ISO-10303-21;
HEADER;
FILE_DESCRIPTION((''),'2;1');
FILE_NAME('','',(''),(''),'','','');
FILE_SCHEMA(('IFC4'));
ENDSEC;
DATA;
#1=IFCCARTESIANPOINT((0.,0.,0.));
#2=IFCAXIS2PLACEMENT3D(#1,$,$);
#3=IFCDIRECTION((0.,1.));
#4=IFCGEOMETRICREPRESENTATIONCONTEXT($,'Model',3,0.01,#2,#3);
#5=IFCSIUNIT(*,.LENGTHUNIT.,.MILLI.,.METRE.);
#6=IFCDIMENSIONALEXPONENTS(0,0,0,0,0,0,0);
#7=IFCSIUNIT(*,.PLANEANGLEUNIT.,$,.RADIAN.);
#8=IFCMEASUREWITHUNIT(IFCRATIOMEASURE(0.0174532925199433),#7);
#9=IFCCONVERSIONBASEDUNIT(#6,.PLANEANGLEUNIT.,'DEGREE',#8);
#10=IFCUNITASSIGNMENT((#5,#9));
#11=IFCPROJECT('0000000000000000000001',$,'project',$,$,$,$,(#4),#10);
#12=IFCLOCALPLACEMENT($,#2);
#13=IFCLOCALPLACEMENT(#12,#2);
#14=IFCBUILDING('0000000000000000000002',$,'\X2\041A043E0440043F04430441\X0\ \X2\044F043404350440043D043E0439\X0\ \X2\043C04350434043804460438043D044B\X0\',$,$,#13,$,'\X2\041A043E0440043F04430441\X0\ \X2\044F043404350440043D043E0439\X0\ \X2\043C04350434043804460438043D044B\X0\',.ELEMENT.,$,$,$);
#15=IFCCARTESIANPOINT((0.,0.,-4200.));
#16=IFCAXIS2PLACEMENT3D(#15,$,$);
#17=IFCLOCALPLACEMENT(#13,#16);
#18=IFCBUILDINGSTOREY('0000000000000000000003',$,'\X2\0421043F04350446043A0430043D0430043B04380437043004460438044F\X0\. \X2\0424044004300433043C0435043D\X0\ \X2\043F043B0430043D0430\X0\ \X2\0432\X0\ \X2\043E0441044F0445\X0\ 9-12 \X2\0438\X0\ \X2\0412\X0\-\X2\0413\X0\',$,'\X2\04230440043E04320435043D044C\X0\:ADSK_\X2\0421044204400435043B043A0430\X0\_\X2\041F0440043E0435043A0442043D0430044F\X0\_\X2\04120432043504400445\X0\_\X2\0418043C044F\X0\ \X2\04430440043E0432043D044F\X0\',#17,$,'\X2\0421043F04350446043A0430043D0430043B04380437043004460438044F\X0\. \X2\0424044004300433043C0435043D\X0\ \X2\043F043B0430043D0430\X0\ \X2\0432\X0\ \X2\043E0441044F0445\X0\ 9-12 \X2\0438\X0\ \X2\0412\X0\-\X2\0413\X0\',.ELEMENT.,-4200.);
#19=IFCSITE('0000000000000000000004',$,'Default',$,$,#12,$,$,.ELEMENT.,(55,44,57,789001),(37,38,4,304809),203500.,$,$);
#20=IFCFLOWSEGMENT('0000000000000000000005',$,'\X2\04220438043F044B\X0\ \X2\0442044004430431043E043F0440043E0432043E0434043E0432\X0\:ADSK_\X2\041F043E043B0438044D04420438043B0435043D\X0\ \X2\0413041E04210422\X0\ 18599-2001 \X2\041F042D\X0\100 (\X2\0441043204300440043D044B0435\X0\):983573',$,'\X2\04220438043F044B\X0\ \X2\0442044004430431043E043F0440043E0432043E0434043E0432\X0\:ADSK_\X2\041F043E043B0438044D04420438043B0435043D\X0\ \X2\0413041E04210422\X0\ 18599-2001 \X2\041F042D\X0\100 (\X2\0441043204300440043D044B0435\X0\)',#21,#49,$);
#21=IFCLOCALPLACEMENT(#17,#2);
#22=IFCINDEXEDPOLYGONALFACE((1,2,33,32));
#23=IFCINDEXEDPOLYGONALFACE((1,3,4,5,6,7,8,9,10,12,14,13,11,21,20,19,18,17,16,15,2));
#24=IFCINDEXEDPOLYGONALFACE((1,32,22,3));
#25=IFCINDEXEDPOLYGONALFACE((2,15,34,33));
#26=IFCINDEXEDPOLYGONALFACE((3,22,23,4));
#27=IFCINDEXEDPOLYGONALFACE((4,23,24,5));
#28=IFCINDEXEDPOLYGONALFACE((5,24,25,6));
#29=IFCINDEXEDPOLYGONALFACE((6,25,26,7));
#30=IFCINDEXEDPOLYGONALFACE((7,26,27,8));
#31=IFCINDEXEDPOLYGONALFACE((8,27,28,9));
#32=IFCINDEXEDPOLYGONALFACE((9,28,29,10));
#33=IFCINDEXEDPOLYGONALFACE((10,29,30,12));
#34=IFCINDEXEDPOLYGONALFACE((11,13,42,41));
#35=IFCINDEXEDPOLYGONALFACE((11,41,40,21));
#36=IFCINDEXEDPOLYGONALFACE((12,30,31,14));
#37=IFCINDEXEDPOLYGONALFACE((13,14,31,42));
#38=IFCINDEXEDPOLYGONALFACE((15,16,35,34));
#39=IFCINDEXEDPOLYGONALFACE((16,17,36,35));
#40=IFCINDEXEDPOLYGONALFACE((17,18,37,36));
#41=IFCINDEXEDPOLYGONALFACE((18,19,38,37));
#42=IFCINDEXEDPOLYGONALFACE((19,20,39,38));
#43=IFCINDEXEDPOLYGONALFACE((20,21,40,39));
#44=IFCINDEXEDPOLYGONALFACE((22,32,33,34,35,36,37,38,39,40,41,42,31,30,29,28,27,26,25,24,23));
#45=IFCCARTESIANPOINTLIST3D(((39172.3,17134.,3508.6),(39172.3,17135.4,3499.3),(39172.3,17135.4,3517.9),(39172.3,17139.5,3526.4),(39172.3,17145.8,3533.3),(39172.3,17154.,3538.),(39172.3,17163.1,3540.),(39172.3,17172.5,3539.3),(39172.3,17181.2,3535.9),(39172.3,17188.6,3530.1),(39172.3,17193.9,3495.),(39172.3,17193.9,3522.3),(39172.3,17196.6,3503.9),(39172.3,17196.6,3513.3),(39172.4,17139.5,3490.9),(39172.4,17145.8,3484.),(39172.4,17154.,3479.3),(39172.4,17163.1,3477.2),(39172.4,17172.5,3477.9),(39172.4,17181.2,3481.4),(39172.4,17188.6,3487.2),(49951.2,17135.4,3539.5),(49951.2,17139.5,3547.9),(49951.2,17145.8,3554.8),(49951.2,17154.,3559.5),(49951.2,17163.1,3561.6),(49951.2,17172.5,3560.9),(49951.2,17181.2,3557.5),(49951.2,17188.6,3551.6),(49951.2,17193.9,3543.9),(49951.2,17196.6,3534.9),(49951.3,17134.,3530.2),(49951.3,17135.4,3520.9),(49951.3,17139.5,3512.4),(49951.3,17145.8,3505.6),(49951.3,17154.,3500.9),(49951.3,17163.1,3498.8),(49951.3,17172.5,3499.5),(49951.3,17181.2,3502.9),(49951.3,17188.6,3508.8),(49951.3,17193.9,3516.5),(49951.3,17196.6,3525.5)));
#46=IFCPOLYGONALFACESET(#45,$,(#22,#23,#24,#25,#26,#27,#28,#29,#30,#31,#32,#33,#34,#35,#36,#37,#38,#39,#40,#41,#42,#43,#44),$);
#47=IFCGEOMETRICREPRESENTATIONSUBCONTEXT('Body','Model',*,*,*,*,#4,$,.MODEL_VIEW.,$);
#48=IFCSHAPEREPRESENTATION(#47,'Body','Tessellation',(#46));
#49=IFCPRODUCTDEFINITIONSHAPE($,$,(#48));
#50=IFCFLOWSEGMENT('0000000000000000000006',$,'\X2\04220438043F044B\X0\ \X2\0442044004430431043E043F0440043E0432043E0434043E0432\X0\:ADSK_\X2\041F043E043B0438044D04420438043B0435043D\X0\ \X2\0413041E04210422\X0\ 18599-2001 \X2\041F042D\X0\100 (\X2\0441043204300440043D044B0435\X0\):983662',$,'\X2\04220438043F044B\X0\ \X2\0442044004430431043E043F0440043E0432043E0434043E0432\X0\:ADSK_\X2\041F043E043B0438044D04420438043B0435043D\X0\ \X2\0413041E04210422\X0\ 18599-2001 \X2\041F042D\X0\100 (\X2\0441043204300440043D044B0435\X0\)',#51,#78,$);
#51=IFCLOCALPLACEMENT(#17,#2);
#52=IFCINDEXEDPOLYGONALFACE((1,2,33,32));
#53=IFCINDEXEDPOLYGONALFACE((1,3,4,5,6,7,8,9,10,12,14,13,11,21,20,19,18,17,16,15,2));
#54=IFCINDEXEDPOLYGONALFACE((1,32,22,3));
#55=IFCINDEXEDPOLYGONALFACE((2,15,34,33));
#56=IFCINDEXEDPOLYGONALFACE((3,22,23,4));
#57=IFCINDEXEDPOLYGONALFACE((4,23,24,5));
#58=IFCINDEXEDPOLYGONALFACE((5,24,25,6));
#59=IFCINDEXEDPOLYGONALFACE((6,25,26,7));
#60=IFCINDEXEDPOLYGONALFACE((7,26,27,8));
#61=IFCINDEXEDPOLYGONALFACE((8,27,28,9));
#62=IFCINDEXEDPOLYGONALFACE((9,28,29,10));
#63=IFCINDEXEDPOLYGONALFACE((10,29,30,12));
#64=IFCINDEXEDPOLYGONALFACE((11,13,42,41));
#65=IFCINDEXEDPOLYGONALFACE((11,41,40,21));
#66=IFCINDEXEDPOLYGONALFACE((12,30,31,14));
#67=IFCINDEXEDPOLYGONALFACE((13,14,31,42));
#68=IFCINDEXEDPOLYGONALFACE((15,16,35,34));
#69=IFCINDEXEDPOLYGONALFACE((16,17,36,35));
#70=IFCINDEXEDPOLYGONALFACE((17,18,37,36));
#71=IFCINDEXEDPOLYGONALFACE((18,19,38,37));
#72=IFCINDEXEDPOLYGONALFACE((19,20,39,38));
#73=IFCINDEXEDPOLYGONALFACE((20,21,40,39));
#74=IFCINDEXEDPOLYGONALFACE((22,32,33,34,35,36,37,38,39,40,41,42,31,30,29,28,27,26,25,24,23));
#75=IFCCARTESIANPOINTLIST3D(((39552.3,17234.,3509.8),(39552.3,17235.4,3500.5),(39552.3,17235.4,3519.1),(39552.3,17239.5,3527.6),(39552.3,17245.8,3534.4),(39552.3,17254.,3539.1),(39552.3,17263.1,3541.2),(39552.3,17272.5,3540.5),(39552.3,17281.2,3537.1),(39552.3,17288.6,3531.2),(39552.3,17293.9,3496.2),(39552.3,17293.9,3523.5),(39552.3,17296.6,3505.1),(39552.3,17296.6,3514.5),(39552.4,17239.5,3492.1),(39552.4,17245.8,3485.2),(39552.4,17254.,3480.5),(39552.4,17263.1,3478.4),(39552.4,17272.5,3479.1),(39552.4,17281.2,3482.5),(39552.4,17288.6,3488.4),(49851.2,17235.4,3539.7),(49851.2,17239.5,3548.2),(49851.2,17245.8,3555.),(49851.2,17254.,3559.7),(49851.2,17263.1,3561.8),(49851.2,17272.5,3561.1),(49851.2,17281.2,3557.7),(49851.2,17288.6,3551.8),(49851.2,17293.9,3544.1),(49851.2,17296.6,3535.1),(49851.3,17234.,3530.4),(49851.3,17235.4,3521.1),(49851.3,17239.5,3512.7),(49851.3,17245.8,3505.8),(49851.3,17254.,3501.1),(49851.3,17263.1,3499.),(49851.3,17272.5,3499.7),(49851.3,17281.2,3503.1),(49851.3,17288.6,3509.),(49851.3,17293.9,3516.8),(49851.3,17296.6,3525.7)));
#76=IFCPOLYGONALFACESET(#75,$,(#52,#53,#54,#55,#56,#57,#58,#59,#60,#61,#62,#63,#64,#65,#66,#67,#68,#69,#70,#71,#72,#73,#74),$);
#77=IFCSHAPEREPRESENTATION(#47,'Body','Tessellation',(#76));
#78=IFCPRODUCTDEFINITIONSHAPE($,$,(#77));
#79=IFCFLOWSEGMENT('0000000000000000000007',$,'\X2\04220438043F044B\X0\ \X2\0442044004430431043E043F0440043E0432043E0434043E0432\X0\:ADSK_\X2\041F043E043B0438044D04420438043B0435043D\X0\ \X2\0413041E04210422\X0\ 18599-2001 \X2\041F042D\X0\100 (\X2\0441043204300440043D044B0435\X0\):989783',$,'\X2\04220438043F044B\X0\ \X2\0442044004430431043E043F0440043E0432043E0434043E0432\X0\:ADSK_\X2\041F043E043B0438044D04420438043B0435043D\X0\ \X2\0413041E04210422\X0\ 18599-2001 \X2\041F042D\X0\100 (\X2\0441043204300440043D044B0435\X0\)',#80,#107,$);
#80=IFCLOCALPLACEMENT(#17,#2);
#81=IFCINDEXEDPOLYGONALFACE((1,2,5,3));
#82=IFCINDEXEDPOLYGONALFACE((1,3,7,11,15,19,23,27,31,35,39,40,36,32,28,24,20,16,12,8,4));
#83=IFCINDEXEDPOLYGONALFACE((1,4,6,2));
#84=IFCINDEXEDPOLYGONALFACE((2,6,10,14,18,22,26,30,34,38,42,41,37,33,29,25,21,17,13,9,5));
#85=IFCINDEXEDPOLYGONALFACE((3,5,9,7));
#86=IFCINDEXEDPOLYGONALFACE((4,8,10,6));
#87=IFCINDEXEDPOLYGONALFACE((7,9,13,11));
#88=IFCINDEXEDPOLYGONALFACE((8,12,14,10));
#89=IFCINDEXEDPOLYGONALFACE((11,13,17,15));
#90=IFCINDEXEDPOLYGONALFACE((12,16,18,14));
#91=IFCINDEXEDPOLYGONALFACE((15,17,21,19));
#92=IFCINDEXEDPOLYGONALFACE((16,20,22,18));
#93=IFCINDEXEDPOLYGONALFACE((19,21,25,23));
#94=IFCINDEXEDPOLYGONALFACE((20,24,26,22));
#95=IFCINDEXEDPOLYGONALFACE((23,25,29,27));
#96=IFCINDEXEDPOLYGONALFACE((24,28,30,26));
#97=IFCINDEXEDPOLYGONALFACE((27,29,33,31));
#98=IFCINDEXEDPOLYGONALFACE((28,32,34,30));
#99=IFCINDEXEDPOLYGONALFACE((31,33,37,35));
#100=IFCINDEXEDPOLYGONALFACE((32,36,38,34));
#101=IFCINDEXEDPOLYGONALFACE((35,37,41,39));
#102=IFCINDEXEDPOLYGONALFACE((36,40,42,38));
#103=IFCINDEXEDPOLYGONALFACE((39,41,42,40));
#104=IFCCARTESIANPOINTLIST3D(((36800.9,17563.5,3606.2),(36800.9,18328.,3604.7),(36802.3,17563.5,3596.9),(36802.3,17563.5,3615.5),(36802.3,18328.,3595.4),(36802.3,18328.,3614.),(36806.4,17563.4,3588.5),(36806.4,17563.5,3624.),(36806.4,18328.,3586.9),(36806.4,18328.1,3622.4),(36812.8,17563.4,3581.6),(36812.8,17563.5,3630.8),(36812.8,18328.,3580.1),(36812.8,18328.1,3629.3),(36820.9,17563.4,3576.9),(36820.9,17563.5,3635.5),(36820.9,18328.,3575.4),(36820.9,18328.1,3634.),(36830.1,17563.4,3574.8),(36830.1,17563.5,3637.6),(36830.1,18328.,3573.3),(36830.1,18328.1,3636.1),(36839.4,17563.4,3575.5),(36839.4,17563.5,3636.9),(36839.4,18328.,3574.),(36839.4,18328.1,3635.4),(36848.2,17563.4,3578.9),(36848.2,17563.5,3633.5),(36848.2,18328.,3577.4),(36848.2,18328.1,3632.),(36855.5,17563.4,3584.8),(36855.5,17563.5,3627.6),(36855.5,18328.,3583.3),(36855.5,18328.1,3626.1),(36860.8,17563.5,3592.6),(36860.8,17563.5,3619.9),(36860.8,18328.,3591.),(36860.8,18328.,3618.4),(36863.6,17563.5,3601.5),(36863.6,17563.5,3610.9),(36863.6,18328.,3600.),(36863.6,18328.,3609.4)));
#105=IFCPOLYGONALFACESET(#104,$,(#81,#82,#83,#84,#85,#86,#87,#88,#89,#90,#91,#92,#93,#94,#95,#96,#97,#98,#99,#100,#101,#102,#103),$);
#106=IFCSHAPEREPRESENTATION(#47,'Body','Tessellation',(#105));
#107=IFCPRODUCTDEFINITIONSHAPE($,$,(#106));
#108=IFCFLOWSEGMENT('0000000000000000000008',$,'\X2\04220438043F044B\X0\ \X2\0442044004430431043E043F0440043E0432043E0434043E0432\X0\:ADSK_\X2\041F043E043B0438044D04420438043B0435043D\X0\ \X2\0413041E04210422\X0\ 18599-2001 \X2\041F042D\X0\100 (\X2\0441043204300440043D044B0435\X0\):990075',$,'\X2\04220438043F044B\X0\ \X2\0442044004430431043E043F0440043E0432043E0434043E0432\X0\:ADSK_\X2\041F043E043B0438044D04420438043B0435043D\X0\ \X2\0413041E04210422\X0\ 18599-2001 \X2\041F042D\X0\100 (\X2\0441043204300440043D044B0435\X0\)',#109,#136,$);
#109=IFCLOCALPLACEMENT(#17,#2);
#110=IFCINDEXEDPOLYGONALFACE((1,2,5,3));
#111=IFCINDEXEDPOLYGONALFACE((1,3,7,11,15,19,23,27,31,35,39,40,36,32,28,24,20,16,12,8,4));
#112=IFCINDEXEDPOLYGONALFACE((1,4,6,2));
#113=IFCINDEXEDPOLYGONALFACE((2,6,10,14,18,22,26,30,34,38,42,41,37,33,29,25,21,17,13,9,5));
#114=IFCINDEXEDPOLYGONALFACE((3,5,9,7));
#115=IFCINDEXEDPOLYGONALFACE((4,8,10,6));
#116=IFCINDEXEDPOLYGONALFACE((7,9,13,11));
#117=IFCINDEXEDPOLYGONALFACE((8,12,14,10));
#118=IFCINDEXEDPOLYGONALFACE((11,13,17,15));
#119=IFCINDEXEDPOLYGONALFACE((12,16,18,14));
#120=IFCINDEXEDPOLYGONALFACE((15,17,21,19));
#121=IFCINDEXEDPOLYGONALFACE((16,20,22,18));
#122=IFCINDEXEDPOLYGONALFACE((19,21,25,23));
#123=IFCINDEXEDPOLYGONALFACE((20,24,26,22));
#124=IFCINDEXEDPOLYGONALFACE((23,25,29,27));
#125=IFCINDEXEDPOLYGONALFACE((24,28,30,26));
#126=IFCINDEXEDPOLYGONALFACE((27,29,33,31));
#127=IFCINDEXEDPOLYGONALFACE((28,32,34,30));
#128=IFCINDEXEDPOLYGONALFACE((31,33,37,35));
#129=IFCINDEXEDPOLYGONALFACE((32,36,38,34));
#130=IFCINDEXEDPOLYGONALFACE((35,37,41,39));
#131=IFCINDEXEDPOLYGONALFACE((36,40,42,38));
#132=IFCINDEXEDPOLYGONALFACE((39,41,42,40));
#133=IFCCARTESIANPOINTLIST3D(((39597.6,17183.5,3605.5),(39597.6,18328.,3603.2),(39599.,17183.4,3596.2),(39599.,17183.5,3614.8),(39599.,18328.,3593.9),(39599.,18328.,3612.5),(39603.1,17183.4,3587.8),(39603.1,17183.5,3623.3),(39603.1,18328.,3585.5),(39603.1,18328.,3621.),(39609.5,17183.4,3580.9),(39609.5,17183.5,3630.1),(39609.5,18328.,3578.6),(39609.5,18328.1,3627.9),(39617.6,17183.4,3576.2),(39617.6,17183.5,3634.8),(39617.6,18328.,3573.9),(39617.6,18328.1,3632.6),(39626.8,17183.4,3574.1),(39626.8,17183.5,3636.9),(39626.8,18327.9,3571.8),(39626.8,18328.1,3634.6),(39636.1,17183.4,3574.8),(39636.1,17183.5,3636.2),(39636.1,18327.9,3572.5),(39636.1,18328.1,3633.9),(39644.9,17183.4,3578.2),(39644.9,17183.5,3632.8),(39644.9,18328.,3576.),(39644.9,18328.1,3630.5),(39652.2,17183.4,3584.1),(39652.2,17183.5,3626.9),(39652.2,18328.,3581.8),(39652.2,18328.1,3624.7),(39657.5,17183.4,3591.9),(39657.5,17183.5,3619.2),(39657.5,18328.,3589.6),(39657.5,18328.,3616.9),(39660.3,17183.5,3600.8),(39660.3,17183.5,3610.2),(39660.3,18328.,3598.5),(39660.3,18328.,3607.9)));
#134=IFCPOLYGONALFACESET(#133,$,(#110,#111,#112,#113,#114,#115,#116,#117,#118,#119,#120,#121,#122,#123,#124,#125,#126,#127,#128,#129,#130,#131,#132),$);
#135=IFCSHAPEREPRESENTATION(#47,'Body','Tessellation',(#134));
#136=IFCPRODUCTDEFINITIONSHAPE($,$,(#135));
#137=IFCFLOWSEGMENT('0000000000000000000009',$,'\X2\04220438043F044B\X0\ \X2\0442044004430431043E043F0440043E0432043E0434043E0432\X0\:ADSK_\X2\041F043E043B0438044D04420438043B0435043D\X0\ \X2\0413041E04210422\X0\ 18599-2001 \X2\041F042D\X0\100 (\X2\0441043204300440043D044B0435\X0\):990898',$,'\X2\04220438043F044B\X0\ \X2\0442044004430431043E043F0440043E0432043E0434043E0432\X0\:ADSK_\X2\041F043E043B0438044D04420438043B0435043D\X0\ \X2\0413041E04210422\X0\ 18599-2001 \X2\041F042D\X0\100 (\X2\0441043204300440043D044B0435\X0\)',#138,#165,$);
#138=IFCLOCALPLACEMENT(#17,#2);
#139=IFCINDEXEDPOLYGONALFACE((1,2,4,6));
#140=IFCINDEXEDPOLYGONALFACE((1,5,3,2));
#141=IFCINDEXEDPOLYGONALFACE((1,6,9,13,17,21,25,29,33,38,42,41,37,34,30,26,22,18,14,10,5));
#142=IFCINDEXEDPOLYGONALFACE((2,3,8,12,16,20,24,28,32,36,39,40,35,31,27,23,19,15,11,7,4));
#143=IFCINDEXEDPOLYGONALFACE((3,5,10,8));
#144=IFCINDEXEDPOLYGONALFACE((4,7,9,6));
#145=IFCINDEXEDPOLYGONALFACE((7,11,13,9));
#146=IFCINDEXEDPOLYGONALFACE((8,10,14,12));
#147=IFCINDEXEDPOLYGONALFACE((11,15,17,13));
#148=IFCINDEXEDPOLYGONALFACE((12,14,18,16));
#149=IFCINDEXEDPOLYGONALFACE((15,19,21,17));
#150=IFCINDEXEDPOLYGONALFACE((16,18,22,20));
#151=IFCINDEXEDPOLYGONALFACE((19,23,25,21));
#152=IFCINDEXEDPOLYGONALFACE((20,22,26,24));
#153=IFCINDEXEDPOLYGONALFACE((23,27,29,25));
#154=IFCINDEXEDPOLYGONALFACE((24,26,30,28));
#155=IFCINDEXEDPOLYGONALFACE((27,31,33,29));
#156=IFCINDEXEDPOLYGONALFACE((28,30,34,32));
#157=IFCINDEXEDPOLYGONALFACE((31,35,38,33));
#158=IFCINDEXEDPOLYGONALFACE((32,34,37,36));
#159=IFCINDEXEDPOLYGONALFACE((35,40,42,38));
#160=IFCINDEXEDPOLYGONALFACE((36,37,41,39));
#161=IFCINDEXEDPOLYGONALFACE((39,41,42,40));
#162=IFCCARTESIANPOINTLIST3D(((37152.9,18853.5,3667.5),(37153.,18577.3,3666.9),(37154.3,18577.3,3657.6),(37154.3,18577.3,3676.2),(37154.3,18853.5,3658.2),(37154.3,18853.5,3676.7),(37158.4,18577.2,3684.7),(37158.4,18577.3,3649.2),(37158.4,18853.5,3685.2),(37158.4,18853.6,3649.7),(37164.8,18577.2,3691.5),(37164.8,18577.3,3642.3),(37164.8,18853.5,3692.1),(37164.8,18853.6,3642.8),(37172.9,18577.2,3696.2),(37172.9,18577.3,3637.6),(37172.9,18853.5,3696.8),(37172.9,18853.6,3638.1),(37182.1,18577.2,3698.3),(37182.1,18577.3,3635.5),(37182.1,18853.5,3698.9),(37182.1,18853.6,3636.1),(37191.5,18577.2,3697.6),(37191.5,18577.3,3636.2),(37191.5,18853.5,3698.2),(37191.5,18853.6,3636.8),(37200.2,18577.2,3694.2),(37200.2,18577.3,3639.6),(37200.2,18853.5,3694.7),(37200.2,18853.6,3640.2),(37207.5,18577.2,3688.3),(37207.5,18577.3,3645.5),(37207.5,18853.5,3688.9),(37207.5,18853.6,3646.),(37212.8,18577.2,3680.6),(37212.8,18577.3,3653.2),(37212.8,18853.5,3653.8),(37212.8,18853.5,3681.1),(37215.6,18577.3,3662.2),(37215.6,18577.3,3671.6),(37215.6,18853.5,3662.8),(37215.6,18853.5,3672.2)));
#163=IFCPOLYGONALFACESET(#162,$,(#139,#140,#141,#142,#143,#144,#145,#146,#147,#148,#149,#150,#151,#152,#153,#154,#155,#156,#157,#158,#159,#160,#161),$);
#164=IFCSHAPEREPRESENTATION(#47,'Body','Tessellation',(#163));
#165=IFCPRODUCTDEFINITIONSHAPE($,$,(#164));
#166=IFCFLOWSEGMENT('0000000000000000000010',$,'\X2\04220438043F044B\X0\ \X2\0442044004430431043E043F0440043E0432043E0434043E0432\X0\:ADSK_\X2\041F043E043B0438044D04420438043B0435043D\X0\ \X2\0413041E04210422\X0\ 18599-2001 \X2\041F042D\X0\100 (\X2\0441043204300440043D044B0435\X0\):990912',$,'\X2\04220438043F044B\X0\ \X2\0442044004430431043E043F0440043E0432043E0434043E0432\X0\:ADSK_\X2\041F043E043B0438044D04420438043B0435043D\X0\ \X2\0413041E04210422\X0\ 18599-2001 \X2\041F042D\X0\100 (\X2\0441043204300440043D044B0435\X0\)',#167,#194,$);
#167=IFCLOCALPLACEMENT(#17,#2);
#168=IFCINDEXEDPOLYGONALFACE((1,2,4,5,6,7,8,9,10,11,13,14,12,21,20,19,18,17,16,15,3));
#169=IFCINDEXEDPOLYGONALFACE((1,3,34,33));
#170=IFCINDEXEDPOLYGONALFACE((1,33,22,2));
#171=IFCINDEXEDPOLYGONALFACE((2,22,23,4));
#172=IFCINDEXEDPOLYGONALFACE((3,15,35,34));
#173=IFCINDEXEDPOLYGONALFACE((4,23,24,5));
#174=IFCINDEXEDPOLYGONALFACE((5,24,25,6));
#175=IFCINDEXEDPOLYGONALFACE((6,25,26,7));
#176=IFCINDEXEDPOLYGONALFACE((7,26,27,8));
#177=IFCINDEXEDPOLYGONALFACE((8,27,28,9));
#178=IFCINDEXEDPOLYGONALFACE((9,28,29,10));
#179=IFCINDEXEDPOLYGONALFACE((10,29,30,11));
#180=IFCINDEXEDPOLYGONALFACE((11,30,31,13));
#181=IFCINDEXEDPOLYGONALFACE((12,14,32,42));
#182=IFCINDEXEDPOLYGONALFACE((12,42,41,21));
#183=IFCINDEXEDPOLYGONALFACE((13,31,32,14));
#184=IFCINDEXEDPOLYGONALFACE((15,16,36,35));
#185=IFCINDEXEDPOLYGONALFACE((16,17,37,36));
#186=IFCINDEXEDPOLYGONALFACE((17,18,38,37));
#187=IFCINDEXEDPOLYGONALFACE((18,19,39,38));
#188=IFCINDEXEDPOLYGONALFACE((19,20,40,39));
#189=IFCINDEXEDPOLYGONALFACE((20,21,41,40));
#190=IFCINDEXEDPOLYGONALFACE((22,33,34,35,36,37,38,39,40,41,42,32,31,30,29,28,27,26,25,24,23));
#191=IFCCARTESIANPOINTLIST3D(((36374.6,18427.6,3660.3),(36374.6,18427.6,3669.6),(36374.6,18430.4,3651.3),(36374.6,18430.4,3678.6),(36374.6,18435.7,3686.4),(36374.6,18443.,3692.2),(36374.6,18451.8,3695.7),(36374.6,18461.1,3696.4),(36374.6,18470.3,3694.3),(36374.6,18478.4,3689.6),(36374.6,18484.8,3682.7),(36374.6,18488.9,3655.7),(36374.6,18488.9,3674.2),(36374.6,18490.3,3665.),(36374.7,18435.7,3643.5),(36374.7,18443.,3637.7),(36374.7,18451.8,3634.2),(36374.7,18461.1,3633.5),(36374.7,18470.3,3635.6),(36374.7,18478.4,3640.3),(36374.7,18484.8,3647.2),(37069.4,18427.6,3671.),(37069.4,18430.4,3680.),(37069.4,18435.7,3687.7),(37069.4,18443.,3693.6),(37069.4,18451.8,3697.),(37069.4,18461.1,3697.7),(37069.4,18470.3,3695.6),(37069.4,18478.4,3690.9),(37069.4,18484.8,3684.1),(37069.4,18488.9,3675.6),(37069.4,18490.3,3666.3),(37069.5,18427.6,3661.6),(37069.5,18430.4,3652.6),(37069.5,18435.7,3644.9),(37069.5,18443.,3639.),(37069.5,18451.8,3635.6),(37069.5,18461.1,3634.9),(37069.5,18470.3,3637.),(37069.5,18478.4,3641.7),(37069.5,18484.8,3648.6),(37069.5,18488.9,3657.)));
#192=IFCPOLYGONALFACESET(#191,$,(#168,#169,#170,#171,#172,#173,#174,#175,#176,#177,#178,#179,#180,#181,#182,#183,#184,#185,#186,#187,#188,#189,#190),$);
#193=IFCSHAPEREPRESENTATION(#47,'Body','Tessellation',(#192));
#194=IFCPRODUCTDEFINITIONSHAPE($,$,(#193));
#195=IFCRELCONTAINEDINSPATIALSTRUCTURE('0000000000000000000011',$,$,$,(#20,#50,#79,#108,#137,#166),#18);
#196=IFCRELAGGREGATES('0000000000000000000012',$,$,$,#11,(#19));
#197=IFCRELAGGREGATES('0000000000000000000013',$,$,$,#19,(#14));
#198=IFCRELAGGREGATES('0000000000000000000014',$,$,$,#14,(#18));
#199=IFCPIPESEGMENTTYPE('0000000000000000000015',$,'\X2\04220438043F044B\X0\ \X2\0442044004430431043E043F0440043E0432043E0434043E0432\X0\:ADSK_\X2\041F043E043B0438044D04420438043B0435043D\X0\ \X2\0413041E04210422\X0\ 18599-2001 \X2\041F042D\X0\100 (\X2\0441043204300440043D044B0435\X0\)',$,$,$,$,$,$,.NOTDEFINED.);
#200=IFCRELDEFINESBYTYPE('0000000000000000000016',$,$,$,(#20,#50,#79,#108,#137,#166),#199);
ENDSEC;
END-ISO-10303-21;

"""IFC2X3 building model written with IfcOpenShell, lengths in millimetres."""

from ifc_helpers import new_model, entity, si_unit, converted_unit, direction, frame, origin, origin_2d_with_axis, place, context, subcontext, project, spatial, circle, extrude, type_object, element, save


model = new_model("IFC2X3")

# Units and contexts
model_context = context("Model", 3, precision=0.01, world=origin(), true_north=direction((0.0, 1.0)))
body_context = subcontext(model_context, "Body", "Model", "MODEL_VIEW")
ifc_project = project(units=[si_unit("LENGTHUNIT", "METRE", prefix="MILLI"), converted_unit("PLANEANGLEUNIT", "DEGREE", entity("IfcRatioMeasure", 0.0174532925199433), si_unit("PLANEANGLEUNIT", "RADIAN"), dimensions=[0, 0, 0, 0, 0, 0, 0])], contexts=[model_context])

# Site, building, storey
site_placement = place(None, origin())
site = spatial("IfcSite", under=ifc_project, at=site_placement, Name="Default", CompositionType="ELEMENT", RefLatitude=(55, 44, 57, 789001), RefLongitude=(37, 38, 4, 304809), RefElevation=203500.0)
building_placement = place(site_placement, origin())
building = spatial("IfcBuilding", under=site, at=building_placement, Name="Корпус ядерной медицины", LongName="Корпус ядерной медицины", CompositionType="ELEMENT")
storey_placement = place(building_placement, frame((0.0, 0.0, -4200.0)))
storey = spatial("IfcBuildingStorey", under=building, at=storey_placement, Name="Спецканализация. Фрагмен плана в осях 9-12 и В-Г", ObjectType="Уровень:ADSK_Стрелка_Проектная_Вверх_Имя уровня", LongName="Спецканализация. Фрагмен плана в осях 9-12 и В-Г", CompositionType="ELEMENT", Elevation=-4200.0)

# Flow segments
pipe_segment_type = type_object("IfcPipeSegmentType", Name="Типы трубопроводов:ADSK_Полиэтилен ГОСТ 18599-2001 ПЭ100 (сварные)", PredefinedType="NOTDEFINED")
flow_segment_1_placement = place(storey_placement, frame((39172.3, 17132.4, 3475.5)))
element("IfcFlowSegment", 1, at=flow_segment_1_placement, inside=storey, type_object=pipe_segment_type, Name="Типы трубопроводов:ADSK_Полиэтилен ГОСТ 18599-2001 ПЭ100 (сварные):983573", ObjectType="Типы трубопроводов:ADSK_Полиэтилен ГОСТ 18599-2001 ПЭ100 (сварные)", context=body_context, shape_type="SweptSolid", body=[
    extrude(circle(Radius=31.5, at=origin_2d_with_axis()), frame((0.1, 33.1, 33.1), z_axis=(0.999998, 0.0, 0.002), x_axis=(0.0, -1.0, 0.0)), (0.0, 0.0, 1.0), 10779.0),
])
flow_segment_2_placement = place(storey_placement, frame((39552.3, 17232.4, 3476.7)))
element("IfcFlowSegment", 2, at=flow_segment_2_placement, inside=storey, type_object=pipe_segment_type, Name="Типы трубопроводов:ADSK_Полиэтилен ГОСТ 18599-2001 ПЭ100 (сварные):983662", ObjectType="Типы трубопроводов:ADSK_Полиэтилен ГОСТ 18599-2001 ПЭ100 (сварные)", context=body_context, shape_type="SweptSolid", body=[
    extrude(circle(Radius=31.5, at=origin_2d_with_axis()), frame((0.1, 33.1, 33.1), z_axis=(0.999998, 0.0, 0.002), x_axis=(0.0, -1.0, 0.0)), (0.0, 0.0, 1.0), 10299.0),
])
flow_segment_3_placement = place(storey_placement, frame((36799.3, 17563.4, 3571.6)))
element("IfcFlowSegment", 3, at=flow_segment_3_placement, inside=storey, type_object=pipe_segment_type, Name="Типы трубопроводов:ADSK_Полиэтилен ГОСТ 18599-2001 ПЭ100 (сварные):989783", ObjectType="Типы трубопроводов:ADSK_Полиэтилен ГОСТ 18599-2001 ПЭ100 (сварные)", context=body_context, shape_type="SweptSolid", body=[
    extrude(circle(Radius=31.5, at=origin_2d_with_axis()), frame((33.1, 764.6, 33.1), z_axis=(0.0, -0.999998, 0.002), x_axis=(-1.0, 0.0, 0.0)), (0.0, 0.0, 1.0), 764.5),
])
flow_segment_4_placement = place(storey_placement, frame((39596.0, 17183.4, 3570.1)))
element("IfcFlowSegment", 4, at=flow_segment_4_placement, inside=storey, type_object=pipe_segment_type, Name="Типы трубопроводов:ADSK_Полиэтилен ГОСТ 18599-2001 ПЭ100 (сварные):990075", ObjectType="Типы трубопроводов:ADSK_Полиэтилен ГОСТ 18599-2001 ПЭ100 (сварные)", context=body_context, shape_type="SweptSolid", body=[
    extrude(circle(Radius=31.5, at=origin_2d_with_axis()), frame((33.1, 1144.6, 33.1), z_axis=(0.0, -0.999998, 0.002), x_axis=(-1.0, 0.0, 0.0)), (0.0, 0.0, 1.0), 1144.5),
])
flow_segment_5_placement = place(storey_placement, frame((37151.3, 18577.2, 3633.8)))
element("IfcFlowSegment", 5, at=flow_segment_5_placement, inside=storey, type_object=pipe_segment_type, Name="Типы трубопроводов:ADSK_Полиэтилен ГОСТ 18599-2001 ПЭ100 (сварные):990898", ObjectType="Типы трубопроводов:ADSK_Полиэтилен ГОСТ 18599-2001 ПЭ100 (сварные)", context=body_context, shape_type="SweptSolid", body=[
    extrude(circle(Radius=31.5, at=origin_2d_with_axis()), frame((33.1, 0.1, 33.1), z_axis=(-0.000004, 0.999998, 0.002), x_axis=(-1.0, -0.000004, 0.0)), (0.0, 0.0, 1.0), 276.2),
])
flow_segment_6_placement = place(storey_placement, frame((36374.6, 18425.7, 3631.8)))
element("IfcFlowSegment", 6, at=flow_segment_6_placement, inside=storey, type_object=pipe_segment_type, Name="Типы трубопроводов:ADSK_Полиэтилен ГОСТ 18599-2001 ПЭ100 (сварные):990912", ObjectType="Типы трубопроводов:ADSK_Полиэтилен ГОСТ 18599-2001 ПЭ100 (сварные)", context=body_context, shape_type="SweptSolid", body=[
    extrude(circle(Radius=31.5, at=origin_2d_with_axis()), frame((0.1, 33.1, 33.1), z_axis=(0.999998, 0.0, 0.001954), x_axis=(0.0, 1.0, 0.0)), (0.0, 0.0, 1.0), 694.8),
])

save(model, "model.ifc")
